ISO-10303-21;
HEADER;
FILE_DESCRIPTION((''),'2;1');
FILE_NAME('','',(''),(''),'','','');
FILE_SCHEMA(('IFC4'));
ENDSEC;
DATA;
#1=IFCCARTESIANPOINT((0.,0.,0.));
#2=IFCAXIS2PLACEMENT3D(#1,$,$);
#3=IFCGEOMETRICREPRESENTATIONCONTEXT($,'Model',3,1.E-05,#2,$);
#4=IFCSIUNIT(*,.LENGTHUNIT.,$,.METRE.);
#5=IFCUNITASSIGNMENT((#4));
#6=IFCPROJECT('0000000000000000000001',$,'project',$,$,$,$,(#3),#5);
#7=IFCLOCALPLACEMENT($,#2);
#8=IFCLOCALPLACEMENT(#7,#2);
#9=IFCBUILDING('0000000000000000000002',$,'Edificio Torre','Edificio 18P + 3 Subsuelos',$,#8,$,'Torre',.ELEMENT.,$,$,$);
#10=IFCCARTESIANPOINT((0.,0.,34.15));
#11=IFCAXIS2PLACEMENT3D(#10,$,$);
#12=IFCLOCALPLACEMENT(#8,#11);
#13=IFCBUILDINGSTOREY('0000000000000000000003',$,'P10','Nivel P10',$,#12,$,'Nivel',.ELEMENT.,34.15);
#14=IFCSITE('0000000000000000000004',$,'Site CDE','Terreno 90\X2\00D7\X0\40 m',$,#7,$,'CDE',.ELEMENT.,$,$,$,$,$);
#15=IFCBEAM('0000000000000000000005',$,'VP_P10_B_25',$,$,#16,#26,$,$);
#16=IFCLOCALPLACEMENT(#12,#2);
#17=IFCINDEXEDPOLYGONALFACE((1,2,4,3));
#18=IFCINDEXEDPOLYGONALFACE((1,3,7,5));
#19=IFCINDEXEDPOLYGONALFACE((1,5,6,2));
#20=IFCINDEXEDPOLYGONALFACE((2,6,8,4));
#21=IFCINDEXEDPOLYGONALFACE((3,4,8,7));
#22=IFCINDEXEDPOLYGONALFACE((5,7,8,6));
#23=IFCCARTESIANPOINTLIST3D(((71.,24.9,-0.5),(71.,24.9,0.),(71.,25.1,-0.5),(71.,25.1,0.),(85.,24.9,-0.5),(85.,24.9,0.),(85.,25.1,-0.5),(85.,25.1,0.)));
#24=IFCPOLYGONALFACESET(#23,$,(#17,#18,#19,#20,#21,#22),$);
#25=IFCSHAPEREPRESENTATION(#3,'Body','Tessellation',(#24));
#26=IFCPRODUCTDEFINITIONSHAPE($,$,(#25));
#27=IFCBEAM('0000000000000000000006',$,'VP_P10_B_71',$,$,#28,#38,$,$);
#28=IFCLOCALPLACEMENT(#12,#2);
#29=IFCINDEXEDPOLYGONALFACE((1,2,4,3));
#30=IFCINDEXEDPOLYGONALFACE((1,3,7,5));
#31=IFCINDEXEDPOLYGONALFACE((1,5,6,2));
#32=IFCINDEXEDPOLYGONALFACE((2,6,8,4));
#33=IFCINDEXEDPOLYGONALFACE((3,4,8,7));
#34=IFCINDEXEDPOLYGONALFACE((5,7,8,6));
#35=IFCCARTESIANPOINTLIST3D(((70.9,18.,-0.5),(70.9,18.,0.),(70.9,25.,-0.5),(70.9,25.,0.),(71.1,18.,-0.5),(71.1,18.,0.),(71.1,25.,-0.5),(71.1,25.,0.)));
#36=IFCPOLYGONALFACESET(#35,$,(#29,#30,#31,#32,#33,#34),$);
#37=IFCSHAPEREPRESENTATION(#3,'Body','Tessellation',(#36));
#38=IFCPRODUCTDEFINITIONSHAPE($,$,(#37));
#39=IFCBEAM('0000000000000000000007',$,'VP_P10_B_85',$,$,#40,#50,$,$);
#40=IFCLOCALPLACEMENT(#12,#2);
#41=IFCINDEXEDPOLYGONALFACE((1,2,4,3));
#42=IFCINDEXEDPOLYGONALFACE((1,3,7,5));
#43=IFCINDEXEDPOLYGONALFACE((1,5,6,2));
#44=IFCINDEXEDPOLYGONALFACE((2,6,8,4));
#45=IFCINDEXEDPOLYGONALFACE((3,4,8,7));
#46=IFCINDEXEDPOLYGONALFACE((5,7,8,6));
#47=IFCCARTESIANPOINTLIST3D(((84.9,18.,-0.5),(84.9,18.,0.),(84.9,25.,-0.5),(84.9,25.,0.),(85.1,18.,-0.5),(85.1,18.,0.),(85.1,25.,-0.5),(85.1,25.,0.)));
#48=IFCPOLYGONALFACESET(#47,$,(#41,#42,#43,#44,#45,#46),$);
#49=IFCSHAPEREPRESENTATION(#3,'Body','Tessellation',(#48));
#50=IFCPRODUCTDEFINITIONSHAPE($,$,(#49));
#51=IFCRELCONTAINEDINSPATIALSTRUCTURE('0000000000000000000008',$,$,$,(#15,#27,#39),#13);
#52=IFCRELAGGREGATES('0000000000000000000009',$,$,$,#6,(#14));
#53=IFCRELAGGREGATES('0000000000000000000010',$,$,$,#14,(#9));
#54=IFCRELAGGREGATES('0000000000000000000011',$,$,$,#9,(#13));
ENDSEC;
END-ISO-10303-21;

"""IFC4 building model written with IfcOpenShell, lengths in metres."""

from ifc_helpers import new_model, si_unit, frame, origin, origin_2d, place, context, project, spatial, rectangle, extrude, element, save


model = new_model("IFC4")

# Units and contexts
model_context = context("Model", 3, precision=1e-05, world=origin())
ifc_project = project(units=[si_unit("LENGTHUNIT", "METRE")], contexts=[model_context])

# Site, building, storey
site_placement = place(None, origin())
site = spatial("IfcSite", under=ifc_project, at=site_placement, Name="Site CDE", Description="Terreno 90×40 m", LongName="CDE", CompositionType="ELEMENT")
building_placement = place(site_placement, origin())
building = spatial("IfcBuilding", under=site, at=building_placement, Name="Edificio Torre", Description="Edificio 18P + 3 Subsuelos", LongName="Torre", CompositionType="ELEMENT")
storey_placement = place(building_placement, frame((0.0, 0.0, 34.15)))
storey = spatial("IfcBuildingStorey", under=building, at=storey_placement, Name="P10", Description="Nivel P10", LongName="Nivel", CompositionType="ELEMENT", Elevation=34.15)

# Beams
for number, where, name in (
    (1, (78.0, 25.0, -0.5), "VP_P10_B_25"),
):
    element("IfcBeam", number, at=place(storey_placement, frame(where)), inside=storey, Name=name, context=model_context, shape_type="SweptSolid", body=[
        extrude(rectangle(XDim=14.0, YDim=0.2, at=origin_2d()), origin(), (0.0, 0.0, 1.0), 0.5),
    ])
for number, where, name in (
    (2, (71.0, 21.5, -0.5), "VP_P10_B_71"),
    (3, (85.0, 21.5, -0.5), "VP_P10_B_85"),
):
    element("IfcBeam", number, at=place(storey_placement, frame(where)), inside=storey, Name=name, context=model_context, shape_type="SweptSolid", body=[
        extrude(rectangle(XDim=0.2, YDim=7.0, at=origin_2d()), origin(), (0.0, 0.0, 1.0), 0.5),
    ])

save(model, "model.ifc")
